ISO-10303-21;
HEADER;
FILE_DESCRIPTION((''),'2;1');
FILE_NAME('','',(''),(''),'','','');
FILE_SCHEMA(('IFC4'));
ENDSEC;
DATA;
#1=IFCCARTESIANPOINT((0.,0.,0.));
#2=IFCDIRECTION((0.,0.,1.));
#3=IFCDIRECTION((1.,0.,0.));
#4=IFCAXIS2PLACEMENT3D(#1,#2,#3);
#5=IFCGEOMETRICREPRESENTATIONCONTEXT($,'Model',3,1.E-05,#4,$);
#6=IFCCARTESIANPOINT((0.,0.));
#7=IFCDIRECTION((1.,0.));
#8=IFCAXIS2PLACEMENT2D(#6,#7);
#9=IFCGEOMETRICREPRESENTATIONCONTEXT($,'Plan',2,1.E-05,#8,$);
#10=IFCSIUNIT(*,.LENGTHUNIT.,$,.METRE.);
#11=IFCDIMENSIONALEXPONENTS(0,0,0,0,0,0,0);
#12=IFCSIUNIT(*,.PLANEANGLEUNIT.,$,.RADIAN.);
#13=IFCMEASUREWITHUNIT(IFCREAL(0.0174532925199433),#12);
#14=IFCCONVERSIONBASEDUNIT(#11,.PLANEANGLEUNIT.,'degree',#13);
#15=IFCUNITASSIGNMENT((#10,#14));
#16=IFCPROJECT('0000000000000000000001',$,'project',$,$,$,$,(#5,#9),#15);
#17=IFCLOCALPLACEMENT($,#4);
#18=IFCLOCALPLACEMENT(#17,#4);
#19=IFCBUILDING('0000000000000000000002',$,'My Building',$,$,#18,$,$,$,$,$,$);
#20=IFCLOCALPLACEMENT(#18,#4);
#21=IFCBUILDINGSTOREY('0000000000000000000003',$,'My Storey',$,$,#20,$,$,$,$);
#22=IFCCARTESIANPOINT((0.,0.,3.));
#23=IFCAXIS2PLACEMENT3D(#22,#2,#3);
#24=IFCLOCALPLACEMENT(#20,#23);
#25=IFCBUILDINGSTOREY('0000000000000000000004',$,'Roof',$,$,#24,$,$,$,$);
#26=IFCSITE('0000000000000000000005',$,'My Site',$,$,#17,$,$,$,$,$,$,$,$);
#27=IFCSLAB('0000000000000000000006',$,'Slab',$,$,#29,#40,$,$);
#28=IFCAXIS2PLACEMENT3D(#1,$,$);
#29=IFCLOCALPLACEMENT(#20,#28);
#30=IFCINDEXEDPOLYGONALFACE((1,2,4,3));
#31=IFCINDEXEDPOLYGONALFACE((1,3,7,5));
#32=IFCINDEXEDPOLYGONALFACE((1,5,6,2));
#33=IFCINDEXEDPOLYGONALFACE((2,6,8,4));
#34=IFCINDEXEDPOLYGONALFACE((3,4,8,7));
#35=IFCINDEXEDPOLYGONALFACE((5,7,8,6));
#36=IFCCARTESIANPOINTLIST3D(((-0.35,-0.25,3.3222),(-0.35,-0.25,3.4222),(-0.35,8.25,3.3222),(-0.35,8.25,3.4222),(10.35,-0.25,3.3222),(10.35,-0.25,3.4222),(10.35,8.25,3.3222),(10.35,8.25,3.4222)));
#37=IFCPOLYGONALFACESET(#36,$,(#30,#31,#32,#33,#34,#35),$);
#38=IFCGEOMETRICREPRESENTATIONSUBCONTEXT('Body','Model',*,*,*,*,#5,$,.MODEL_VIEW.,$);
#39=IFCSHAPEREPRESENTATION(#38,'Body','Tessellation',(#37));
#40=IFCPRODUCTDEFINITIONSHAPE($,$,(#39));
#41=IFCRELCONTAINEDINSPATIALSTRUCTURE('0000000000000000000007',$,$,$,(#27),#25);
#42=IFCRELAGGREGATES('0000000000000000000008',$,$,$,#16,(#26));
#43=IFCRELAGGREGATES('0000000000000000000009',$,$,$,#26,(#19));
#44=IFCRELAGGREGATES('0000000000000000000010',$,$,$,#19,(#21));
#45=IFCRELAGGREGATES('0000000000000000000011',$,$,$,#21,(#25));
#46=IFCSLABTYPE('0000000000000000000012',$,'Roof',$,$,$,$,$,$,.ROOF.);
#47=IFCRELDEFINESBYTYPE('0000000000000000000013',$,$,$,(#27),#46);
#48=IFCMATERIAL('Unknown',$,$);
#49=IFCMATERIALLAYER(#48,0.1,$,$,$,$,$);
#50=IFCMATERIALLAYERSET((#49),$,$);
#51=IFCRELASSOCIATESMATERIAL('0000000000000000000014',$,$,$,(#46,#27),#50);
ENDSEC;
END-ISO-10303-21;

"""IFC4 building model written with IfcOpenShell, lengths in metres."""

from ifc_helpers import new_model, entity, si_unit, converted_unit, frame, origin_with_axes, origin_2d_with_axis, place, context, subcontext, project, spatial, indexed_curve, outline, extrude, material, layer, layer_set, layer_usage, type_object, element, save


model = new_model("IFC4")

# Units and contexts
model_context = context("Model", 3, precision=1e-05, world=origin_with_axes())
plan_context = context("Plan", 2, precision=1e-05, world=origin_2d_with_axis())
body_context = subcontext(model_context, "Body", "Model", "MODEL_VIEW")
ifc_project = project(units=[si_unit("LENGTHUNIT", "METRE"), converted_unit("PLANEANGLEUNIT", "degree", entity("IfcReal", 0.0174532925199433), si_unit("PLANEANGLEUNIT", "RADIAN"), dimensions=[0, 0, 0, 0, 0, 0, 0])], contexts=[model_context, plan_context])

# Site, building, storeys
site_placement = place(None, origin_with_axes())
site = spatial("IfcSite", under=ifc_project, at=site_placement, Name="My Site")
building_placement = place(site_placement, origin_with_axes())
building = spatial("IfcBuilding", under=site, at=building_placement, Name="My Building")
storey_1_placement = place(building_placement, origin_with_axes())
storey_1 = spatial("IfcBuildingStorey", under=building, at=storey_1_placement, Name="My Storey")
storey_2_placement = place(storey_1_placement, frame((0.0, 0.0, 3.0), z_axis=(0.0, 0.0, 1.0), x_axis=(1.0, 0.0, 0.0)))
storey_2 = spatial("IfcBuildingStorey", under=storey_1, at=storey_2_placement, Name="Roof")

# Slab
ifc_material = material(Name="Unknown")
ifc_layer = layer(ifc_material, 0.1)
ifc_layer_set = layer_set([ifc_layer])
ifc_layer_usage = layer_usage(ifc_layer_set, "AXIS3", "POSITIVE", -0.1)
slab_type = type_object("IfcSlabType", Name="Roof", PredefinedType="ROOF", material=ifc_layer_set)
slab_placement = place(storey_2_placement, frame((-0.35, 8.25, 0.4222), z_axis=(0.0, 0.0, 1.0), x_axis=(1.0, 0.0, 0.0)))
element("IfcSlab", 1, at=slab_placement, inside=storey_2, type_object=slab_type, material=ifc_layer_usage, Name="Slab", context=body_context, shape_type="SweptSolid", body=[
    extrude(outline(indexed_curve([(0.0, 0.0), (0.0, -8.5), (10.7, -8.5), (10.7, 0.0), (0.0, 0.0)])), frame((0.0, 0.0, -0.1), z_axis=(0.0, 0.0, 1.0), x_axis=(1.0, 0.0, 0.0)), (0.0, 0.0, 1.0), 0.1),
])

save(model, "model.ifc")
